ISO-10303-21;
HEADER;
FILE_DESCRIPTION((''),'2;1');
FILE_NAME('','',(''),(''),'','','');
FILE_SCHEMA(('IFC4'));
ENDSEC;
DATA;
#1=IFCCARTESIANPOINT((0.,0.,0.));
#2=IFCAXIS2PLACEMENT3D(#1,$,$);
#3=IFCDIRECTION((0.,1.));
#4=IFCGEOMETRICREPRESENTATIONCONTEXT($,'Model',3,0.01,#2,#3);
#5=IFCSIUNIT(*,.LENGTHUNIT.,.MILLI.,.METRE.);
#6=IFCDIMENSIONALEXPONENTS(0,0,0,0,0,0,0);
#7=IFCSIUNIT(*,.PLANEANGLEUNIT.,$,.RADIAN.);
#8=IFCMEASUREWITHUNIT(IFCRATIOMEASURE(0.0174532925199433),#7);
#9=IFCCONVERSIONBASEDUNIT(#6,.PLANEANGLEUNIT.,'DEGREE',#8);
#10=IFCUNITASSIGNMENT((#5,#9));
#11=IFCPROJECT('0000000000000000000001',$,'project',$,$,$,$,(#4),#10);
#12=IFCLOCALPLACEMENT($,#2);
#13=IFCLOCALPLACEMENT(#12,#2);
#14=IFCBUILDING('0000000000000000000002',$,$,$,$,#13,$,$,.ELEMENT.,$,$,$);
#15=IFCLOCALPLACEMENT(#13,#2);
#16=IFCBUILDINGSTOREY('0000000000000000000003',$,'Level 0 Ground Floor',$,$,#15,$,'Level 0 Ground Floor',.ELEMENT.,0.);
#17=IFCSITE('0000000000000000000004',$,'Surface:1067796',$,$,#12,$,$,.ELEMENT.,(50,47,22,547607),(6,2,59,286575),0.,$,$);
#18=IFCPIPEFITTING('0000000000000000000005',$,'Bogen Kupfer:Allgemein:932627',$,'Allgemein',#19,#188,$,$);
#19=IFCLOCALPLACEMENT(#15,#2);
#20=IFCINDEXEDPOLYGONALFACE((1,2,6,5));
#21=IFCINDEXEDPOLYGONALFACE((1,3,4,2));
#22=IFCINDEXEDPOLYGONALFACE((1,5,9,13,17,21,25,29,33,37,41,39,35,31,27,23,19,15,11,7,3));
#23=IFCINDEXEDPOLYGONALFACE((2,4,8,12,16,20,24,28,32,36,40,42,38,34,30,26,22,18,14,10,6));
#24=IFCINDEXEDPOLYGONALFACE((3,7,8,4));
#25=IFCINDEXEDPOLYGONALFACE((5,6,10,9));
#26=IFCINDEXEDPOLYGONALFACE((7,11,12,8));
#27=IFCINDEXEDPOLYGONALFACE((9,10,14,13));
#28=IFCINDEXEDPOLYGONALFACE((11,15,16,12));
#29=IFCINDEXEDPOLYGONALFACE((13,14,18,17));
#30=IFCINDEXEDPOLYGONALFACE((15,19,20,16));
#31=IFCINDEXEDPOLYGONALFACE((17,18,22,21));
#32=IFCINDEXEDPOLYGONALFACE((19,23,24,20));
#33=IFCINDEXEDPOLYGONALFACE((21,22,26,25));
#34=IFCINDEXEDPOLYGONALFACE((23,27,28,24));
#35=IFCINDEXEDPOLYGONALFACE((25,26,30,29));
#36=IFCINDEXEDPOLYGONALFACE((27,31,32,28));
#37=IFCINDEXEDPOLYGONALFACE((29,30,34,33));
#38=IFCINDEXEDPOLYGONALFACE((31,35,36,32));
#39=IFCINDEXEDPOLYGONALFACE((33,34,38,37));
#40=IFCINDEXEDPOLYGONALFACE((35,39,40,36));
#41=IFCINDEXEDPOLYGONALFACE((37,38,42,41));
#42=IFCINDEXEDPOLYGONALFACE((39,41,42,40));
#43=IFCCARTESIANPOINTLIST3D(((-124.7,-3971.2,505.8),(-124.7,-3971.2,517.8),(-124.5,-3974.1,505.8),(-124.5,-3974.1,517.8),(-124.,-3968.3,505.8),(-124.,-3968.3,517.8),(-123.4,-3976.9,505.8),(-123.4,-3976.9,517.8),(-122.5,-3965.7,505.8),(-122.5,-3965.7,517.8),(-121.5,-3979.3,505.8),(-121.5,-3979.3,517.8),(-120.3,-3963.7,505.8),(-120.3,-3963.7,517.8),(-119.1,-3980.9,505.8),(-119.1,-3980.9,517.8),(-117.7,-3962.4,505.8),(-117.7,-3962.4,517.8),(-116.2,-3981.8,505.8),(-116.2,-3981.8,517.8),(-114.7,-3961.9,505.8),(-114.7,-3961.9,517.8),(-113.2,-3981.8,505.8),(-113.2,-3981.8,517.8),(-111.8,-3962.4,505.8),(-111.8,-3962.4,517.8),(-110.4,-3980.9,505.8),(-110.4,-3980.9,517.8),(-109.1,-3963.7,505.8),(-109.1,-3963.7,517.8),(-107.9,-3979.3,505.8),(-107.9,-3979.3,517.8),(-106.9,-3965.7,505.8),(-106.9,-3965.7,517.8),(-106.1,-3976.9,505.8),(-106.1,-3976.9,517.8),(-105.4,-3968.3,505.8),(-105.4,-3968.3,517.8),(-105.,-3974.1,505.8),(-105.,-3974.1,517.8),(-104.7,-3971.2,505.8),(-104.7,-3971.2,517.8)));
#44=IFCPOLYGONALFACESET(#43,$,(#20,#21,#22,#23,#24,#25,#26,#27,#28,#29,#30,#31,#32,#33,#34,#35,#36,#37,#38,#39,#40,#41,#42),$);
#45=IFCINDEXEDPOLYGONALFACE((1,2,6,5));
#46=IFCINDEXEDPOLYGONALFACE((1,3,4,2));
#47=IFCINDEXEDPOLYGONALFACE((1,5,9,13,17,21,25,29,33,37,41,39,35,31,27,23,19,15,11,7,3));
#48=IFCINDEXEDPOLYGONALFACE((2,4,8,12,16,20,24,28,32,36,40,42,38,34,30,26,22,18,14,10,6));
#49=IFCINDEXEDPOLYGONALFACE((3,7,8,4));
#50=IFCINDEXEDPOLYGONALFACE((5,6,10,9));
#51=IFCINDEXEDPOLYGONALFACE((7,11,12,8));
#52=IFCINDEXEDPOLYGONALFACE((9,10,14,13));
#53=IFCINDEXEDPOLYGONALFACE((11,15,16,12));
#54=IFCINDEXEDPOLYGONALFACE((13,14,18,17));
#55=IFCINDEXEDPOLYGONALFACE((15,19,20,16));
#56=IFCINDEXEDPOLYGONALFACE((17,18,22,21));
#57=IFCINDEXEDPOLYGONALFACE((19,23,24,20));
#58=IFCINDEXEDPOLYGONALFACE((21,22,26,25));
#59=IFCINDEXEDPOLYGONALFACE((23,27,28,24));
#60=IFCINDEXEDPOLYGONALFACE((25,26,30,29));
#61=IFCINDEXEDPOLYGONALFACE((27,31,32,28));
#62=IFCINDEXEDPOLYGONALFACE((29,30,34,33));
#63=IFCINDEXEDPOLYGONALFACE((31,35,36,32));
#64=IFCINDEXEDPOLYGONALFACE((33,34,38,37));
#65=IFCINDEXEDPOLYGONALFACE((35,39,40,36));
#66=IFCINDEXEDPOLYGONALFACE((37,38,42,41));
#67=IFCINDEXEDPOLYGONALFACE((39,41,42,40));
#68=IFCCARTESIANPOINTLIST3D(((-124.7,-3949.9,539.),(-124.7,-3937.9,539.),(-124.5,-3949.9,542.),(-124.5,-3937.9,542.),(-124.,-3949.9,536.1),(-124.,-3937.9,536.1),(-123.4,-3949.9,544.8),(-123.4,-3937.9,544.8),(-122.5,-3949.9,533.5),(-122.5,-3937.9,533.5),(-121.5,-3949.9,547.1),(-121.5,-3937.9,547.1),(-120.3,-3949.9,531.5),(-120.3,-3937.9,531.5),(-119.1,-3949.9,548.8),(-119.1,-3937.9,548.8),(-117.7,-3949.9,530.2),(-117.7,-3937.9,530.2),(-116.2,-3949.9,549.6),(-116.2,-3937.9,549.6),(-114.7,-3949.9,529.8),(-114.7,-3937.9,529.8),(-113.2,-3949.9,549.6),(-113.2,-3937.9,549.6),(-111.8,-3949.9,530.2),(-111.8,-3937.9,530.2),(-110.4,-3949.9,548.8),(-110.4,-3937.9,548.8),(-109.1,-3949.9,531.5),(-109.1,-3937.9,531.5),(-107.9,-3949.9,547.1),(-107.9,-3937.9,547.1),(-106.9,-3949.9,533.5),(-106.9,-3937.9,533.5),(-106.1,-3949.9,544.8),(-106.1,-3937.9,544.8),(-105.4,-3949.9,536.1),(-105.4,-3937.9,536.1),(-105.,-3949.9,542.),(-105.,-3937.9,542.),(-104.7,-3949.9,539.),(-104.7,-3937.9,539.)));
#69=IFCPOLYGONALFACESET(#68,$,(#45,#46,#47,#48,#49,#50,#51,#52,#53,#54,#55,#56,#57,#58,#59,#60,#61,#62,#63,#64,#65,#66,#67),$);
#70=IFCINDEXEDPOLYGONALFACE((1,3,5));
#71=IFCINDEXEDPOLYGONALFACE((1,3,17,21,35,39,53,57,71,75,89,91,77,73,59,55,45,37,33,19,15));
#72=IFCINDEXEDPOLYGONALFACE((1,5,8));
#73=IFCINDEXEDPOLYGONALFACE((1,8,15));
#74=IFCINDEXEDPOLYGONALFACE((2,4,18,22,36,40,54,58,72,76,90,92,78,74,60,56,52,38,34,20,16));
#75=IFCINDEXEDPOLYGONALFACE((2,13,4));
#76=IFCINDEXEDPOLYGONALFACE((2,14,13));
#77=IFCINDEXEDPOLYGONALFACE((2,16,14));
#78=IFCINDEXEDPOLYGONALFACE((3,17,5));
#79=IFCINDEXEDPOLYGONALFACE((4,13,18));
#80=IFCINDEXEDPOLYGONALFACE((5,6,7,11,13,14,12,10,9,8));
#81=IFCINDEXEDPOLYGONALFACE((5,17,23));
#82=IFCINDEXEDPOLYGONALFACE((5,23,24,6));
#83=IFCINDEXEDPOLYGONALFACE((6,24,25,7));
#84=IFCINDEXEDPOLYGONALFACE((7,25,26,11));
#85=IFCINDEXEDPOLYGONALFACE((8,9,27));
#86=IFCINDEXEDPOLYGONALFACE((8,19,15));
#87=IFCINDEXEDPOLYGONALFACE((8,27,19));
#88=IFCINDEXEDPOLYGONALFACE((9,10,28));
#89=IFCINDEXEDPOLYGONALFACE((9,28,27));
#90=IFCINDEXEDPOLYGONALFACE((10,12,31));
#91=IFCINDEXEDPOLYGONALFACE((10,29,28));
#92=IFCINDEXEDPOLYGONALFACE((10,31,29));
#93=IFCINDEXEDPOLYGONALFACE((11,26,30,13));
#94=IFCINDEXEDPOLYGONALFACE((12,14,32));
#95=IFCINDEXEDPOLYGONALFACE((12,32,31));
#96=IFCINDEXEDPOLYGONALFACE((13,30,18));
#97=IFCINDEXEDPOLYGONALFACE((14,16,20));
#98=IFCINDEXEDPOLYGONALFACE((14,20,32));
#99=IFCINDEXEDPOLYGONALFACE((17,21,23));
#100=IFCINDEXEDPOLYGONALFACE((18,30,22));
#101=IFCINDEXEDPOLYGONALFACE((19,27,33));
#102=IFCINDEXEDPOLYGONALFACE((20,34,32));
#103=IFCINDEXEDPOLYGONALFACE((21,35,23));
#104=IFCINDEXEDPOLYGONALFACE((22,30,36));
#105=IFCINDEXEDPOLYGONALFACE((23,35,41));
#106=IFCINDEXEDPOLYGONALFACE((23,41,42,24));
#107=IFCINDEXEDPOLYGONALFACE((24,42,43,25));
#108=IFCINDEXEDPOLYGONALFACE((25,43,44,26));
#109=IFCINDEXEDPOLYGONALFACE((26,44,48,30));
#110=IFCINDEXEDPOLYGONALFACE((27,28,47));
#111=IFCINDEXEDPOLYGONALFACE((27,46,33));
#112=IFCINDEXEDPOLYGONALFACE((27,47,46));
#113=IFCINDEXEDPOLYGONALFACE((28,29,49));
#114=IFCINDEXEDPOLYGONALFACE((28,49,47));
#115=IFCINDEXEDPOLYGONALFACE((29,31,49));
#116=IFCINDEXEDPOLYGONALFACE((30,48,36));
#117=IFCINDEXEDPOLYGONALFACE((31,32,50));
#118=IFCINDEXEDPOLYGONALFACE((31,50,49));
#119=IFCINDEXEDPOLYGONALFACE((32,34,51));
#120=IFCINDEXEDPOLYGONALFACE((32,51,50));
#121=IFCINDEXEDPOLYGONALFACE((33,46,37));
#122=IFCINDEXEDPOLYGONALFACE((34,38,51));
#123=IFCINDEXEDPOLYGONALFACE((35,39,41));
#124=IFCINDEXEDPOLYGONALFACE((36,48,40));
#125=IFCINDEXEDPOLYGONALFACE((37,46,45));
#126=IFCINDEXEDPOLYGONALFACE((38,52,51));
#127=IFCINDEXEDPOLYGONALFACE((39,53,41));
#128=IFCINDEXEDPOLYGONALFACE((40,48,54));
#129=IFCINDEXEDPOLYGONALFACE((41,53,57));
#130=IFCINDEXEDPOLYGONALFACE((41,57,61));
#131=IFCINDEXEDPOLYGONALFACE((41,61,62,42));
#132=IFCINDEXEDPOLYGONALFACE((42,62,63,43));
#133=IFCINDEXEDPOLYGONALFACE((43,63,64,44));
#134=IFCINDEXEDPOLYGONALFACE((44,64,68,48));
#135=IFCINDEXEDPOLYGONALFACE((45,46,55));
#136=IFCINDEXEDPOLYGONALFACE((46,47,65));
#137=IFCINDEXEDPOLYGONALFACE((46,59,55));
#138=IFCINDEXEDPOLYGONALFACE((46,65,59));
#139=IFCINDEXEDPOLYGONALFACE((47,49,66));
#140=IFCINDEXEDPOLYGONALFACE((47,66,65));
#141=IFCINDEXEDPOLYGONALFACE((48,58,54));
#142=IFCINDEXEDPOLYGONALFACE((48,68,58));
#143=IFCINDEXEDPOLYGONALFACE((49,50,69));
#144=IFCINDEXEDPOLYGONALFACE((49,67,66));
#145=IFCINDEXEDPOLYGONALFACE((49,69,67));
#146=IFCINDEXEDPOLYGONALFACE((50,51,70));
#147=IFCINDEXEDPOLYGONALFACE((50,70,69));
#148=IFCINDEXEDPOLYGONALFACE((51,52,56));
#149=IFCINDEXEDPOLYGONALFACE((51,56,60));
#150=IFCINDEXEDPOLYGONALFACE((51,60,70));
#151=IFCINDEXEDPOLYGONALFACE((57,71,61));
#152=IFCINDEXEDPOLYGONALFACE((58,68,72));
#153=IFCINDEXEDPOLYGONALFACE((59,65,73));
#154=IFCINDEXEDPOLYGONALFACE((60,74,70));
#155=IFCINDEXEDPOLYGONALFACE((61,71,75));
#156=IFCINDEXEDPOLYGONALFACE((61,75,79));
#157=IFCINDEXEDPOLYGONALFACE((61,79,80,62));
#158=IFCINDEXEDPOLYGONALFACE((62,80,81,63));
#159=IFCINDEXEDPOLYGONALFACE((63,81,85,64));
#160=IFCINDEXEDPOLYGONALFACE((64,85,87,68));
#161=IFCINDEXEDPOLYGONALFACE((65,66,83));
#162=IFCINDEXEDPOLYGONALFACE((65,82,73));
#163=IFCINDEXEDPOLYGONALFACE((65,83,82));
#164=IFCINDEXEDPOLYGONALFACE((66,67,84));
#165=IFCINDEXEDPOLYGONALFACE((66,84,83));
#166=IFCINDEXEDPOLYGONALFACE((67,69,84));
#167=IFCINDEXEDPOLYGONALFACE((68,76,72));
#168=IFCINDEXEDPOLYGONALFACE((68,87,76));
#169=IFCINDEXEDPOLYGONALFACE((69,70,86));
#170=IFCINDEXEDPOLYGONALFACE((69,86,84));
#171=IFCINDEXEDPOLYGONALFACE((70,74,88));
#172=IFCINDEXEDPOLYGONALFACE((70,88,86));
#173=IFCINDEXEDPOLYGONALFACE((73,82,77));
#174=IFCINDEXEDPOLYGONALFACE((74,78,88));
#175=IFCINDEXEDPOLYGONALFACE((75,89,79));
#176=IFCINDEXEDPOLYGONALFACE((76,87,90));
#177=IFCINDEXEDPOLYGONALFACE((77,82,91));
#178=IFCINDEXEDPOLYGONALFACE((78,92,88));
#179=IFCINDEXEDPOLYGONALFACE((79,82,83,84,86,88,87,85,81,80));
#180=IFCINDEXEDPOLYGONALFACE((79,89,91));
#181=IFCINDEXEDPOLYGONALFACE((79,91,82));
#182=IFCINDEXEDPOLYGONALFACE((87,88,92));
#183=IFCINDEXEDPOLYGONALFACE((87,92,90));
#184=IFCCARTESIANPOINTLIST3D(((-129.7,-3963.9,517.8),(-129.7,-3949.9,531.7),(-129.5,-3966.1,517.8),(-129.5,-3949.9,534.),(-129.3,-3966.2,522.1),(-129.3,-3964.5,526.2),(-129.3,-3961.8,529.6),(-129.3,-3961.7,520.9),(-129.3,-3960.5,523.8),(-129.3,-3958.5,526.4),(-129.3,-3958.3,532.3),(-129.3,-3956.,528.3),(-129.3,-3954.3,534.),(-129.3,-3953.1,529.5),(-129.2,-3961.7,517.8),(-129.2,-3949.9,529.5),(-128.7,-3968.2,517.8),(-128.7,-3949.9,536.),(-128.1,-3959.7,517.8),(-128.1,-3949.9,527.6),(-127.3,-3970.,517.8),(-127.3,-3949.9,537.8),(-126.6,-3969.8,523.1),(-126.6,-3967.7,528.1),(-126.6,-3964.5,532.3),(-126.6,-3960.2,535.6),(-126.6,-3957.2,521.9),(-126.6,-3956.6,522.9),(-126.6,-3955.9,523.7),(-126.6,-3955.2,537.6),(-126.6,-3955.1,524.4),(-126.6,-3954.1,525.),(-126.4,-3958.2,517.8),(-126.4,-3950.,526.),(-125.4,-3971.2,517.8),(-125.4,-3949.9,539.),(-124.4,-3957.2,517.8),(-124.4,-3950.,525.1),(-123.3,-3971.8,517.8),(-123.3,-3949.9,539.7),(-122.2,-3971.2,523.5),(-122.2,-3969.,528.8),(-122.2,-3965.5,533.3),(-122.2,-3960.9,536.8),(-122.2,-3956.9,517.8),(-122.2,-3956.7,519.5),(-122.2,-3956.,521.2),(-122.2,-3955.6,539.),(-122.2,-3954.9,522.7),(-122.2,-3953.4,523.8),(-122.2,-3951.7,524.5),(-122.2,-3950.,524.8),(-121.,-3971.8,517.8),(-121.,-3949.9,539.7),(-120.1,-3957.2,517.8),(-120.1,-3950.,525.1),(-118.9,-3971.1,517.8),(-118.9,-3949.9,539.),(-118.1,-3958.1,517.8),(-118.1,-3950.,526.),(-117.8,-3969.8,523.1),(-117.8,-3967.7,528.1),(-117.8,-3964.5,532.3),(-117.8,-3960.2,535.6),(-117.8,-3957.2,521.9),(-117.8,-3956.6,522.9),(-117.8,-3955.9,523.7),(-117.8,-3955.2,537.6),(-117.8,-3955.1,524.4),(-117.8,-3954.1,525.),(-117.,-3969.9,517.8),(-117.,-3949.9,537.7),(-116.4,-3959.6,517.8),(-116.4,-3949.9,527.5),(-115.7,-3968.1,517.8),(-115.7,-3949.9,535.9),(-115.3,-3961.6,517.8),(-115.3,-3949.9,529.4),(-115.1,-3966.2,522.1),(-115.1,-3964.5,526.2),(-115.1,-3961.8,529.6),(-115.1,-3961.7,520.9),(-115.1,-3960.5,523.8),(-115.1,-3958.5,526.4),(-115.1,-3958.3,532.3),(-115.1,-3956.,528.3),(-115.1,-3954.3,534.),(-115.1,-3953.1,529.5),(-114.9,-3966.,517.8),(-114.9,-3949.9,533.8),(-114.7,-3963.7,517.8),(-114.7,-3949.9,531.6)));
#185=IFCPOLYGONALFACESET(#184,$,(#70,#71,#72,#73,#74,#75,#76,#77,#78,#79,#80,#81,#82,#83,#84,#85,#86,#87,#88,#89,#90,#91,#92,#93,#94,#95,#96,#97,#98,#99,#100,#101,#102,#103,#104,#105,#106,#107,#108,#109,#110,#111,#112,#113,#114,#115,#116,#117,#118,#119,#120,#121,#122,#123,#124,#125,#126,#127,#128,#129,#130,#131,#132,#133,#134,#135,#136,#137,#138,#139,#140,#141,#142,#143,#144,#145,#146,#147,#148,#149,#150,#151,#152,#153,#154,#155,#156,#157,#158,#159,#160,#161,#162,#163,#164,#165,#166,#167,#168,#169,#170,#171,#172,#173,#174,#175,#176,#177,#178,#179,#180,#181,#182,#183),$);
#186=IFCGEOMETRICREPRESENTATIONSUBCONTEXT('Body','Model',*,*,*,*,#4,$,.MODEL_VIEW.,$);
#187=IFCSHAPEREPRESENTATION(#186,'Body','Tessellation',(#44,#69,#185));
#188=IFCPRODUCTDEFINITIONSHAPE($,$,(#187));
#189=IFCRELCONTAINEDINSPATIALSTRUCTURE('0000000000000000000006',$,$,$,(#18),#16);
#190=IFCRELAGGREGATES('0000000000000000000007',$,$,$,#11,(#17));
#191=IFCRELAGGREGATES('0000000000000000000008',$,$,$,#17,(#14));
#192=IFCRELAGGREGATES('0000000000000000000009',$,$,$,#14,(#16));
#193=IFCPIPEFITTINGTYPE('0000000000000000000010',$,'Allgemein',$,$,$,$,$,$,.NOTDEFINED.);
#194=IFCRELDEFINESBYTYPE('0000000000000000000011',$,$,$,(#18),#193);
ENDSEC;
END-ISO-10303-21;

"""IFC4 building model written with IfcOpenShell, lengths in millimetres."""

from ifc_helpers import new_model, entity, si_unit, converted_unit, direction, frame, frame_2d, origin, place, context, subcontext, project, spatial, circle, extrude, source, transform, mapped, type_object, type_shapes, element, save


model = new_model("IFC4")

# Units and contexts
model_context = context("Model", 3, precision=0.01, world=origin(), true_north=direction((0.0, 1.0)))
body_context = subcontext(model_context, "Body", "Model", "MODEL_VIEW")
ifc_project = project(units=[si_unit("LENGTHUNIT", "METRE", prefix="MILLI"), converted_unit("PLANEANGLEUNIT", "DEGREE", entity("IfcRatioMeasure", 0.0174532925199433), si_unit("PLANEANGLEUNIT", "RADIAN"), dimensions=[0, 0, 0, 0, 0, 0, 0])], contexts=[model_context])

# Site, building, storey
site_placement = place(None, origin())
site = spatial("IfcSite", under=ifc_project, at=site_placement, Name="Surface:1067796", CompositionType="ELEMENT", RefLatitude=(50, 47, 22, 547607), RefLongitude=(6, 2, 59, 286575), RefElevation=0.0)
building_placement = place(site_placement, origin())
building = spatial("IfcBuilding", under=site, at=building_placement, CompositionType="ELEMENT")
storey_placement = place(building_placement, origin())
storey = spatial("IfcBuildingStorey", under=building, at=storey_placement, Name="Level 0 Ground Floor", LongName="Level 0 Ground Floor", CompositionType="ELEMENT", Elevation=0.0)

# Pipe fitting
pipe_fitting_type_1 = type_object("IfcPipeFittingType", Name="Allgemein", PredefinedType="NOTDEFINED")
ifc_direction = entity("IfcDirection", [0.0, 0.0, -1.0])
trimmed_curve = entity("IfcTrimmedCurve", entity("IfcCircle", entity("IfcAxis2Placement2D", entity("IfcCartesianPoint", [-14.5, 0.0]), entity("IfcDirection", [0.0, 1.0])), 14.5), [entity("IfcParameterValue", 270.0)], [entity("IfcParameterValue", 0.0)], True, "PARAMETER")
shared_shape_1 = source(origin(), body_context, "Body", "SolidModel", [
    extrude(circle(Radius=10.0, at=frame_2d((0.0, 0.0), x_axis=(1.0, 0.0))), frame((0.0, 22.0, 0.0), z_axis=(0.0, 1.0, 0.0), x_axis=(-1.0, 0.0, 0.0)), (0.0, 0.0, 1.0), 12.0),
    extrude(circle(Radius=10.0, at=frame_2d((0.0, 0.0), x_axis=(1.0, 0.0))), frame((-34.0, 0.0, 0.0), z_axis=(1.0, 0.0, 0.0), x_axis=(0.0, 1.0, 0.0)), (0.0, 0.0, 1.0), 12.0),
    entity("IfcSurfaceCurveSweptAreaSolid", entity("IfcCircleProfileDef", "AREA", None, entity("IfcAxis2Placement2D", entity("IfcCartesianPoint", [0.0, 7.5]), entity("IfcDirection", [1.0, 0.0])), 7.5), entity("IfcAxis2Placement3D", entity("IfcCartesianPoint", [-7.5, 22.0, 0.0]), ifc_direction, entity("IfcDirection", [1.0, 0.0, 0.0])), trimmed_curve, 0.0, 90.0, entity("IfcSurfaceOfLinearExtrusion", entity("IfcArbitraryOpenProfileDef", "CURVE", None, trimmed_curve), entity("IfcAxis2Placement3D", entity("IfcCartesianPoint", [0.0, 0.0, -304.8])), ifc_direction, 1.0)),
])
type_shapes(pipe_fitting_type_1, [shared_shape_1])
for number, where, z_axis, x_axis, name in (
    (1, (-114.7, -3971.9, 539.8), (1.0, 0.0, 0.0), (0.0, -1.0, 0.0), "Bogen Kupfer:Allgemein:932627"),
):
    element("IfcPipeFitting", number, at=place(storey_placement, frame(where, z_axis=z_axis, x_axis=x_axis)), inside=storey, type_object=pipe_fitting_type_1, Name=name, ObjectType="Allgemein", context=body_context, shape_type="MappedRepresentation", body=[
        mapped(shared_shape_1, transform((0.0, 0.0, 0.0), scale=1.0)),
    ])

save(model, "model.ifc")
